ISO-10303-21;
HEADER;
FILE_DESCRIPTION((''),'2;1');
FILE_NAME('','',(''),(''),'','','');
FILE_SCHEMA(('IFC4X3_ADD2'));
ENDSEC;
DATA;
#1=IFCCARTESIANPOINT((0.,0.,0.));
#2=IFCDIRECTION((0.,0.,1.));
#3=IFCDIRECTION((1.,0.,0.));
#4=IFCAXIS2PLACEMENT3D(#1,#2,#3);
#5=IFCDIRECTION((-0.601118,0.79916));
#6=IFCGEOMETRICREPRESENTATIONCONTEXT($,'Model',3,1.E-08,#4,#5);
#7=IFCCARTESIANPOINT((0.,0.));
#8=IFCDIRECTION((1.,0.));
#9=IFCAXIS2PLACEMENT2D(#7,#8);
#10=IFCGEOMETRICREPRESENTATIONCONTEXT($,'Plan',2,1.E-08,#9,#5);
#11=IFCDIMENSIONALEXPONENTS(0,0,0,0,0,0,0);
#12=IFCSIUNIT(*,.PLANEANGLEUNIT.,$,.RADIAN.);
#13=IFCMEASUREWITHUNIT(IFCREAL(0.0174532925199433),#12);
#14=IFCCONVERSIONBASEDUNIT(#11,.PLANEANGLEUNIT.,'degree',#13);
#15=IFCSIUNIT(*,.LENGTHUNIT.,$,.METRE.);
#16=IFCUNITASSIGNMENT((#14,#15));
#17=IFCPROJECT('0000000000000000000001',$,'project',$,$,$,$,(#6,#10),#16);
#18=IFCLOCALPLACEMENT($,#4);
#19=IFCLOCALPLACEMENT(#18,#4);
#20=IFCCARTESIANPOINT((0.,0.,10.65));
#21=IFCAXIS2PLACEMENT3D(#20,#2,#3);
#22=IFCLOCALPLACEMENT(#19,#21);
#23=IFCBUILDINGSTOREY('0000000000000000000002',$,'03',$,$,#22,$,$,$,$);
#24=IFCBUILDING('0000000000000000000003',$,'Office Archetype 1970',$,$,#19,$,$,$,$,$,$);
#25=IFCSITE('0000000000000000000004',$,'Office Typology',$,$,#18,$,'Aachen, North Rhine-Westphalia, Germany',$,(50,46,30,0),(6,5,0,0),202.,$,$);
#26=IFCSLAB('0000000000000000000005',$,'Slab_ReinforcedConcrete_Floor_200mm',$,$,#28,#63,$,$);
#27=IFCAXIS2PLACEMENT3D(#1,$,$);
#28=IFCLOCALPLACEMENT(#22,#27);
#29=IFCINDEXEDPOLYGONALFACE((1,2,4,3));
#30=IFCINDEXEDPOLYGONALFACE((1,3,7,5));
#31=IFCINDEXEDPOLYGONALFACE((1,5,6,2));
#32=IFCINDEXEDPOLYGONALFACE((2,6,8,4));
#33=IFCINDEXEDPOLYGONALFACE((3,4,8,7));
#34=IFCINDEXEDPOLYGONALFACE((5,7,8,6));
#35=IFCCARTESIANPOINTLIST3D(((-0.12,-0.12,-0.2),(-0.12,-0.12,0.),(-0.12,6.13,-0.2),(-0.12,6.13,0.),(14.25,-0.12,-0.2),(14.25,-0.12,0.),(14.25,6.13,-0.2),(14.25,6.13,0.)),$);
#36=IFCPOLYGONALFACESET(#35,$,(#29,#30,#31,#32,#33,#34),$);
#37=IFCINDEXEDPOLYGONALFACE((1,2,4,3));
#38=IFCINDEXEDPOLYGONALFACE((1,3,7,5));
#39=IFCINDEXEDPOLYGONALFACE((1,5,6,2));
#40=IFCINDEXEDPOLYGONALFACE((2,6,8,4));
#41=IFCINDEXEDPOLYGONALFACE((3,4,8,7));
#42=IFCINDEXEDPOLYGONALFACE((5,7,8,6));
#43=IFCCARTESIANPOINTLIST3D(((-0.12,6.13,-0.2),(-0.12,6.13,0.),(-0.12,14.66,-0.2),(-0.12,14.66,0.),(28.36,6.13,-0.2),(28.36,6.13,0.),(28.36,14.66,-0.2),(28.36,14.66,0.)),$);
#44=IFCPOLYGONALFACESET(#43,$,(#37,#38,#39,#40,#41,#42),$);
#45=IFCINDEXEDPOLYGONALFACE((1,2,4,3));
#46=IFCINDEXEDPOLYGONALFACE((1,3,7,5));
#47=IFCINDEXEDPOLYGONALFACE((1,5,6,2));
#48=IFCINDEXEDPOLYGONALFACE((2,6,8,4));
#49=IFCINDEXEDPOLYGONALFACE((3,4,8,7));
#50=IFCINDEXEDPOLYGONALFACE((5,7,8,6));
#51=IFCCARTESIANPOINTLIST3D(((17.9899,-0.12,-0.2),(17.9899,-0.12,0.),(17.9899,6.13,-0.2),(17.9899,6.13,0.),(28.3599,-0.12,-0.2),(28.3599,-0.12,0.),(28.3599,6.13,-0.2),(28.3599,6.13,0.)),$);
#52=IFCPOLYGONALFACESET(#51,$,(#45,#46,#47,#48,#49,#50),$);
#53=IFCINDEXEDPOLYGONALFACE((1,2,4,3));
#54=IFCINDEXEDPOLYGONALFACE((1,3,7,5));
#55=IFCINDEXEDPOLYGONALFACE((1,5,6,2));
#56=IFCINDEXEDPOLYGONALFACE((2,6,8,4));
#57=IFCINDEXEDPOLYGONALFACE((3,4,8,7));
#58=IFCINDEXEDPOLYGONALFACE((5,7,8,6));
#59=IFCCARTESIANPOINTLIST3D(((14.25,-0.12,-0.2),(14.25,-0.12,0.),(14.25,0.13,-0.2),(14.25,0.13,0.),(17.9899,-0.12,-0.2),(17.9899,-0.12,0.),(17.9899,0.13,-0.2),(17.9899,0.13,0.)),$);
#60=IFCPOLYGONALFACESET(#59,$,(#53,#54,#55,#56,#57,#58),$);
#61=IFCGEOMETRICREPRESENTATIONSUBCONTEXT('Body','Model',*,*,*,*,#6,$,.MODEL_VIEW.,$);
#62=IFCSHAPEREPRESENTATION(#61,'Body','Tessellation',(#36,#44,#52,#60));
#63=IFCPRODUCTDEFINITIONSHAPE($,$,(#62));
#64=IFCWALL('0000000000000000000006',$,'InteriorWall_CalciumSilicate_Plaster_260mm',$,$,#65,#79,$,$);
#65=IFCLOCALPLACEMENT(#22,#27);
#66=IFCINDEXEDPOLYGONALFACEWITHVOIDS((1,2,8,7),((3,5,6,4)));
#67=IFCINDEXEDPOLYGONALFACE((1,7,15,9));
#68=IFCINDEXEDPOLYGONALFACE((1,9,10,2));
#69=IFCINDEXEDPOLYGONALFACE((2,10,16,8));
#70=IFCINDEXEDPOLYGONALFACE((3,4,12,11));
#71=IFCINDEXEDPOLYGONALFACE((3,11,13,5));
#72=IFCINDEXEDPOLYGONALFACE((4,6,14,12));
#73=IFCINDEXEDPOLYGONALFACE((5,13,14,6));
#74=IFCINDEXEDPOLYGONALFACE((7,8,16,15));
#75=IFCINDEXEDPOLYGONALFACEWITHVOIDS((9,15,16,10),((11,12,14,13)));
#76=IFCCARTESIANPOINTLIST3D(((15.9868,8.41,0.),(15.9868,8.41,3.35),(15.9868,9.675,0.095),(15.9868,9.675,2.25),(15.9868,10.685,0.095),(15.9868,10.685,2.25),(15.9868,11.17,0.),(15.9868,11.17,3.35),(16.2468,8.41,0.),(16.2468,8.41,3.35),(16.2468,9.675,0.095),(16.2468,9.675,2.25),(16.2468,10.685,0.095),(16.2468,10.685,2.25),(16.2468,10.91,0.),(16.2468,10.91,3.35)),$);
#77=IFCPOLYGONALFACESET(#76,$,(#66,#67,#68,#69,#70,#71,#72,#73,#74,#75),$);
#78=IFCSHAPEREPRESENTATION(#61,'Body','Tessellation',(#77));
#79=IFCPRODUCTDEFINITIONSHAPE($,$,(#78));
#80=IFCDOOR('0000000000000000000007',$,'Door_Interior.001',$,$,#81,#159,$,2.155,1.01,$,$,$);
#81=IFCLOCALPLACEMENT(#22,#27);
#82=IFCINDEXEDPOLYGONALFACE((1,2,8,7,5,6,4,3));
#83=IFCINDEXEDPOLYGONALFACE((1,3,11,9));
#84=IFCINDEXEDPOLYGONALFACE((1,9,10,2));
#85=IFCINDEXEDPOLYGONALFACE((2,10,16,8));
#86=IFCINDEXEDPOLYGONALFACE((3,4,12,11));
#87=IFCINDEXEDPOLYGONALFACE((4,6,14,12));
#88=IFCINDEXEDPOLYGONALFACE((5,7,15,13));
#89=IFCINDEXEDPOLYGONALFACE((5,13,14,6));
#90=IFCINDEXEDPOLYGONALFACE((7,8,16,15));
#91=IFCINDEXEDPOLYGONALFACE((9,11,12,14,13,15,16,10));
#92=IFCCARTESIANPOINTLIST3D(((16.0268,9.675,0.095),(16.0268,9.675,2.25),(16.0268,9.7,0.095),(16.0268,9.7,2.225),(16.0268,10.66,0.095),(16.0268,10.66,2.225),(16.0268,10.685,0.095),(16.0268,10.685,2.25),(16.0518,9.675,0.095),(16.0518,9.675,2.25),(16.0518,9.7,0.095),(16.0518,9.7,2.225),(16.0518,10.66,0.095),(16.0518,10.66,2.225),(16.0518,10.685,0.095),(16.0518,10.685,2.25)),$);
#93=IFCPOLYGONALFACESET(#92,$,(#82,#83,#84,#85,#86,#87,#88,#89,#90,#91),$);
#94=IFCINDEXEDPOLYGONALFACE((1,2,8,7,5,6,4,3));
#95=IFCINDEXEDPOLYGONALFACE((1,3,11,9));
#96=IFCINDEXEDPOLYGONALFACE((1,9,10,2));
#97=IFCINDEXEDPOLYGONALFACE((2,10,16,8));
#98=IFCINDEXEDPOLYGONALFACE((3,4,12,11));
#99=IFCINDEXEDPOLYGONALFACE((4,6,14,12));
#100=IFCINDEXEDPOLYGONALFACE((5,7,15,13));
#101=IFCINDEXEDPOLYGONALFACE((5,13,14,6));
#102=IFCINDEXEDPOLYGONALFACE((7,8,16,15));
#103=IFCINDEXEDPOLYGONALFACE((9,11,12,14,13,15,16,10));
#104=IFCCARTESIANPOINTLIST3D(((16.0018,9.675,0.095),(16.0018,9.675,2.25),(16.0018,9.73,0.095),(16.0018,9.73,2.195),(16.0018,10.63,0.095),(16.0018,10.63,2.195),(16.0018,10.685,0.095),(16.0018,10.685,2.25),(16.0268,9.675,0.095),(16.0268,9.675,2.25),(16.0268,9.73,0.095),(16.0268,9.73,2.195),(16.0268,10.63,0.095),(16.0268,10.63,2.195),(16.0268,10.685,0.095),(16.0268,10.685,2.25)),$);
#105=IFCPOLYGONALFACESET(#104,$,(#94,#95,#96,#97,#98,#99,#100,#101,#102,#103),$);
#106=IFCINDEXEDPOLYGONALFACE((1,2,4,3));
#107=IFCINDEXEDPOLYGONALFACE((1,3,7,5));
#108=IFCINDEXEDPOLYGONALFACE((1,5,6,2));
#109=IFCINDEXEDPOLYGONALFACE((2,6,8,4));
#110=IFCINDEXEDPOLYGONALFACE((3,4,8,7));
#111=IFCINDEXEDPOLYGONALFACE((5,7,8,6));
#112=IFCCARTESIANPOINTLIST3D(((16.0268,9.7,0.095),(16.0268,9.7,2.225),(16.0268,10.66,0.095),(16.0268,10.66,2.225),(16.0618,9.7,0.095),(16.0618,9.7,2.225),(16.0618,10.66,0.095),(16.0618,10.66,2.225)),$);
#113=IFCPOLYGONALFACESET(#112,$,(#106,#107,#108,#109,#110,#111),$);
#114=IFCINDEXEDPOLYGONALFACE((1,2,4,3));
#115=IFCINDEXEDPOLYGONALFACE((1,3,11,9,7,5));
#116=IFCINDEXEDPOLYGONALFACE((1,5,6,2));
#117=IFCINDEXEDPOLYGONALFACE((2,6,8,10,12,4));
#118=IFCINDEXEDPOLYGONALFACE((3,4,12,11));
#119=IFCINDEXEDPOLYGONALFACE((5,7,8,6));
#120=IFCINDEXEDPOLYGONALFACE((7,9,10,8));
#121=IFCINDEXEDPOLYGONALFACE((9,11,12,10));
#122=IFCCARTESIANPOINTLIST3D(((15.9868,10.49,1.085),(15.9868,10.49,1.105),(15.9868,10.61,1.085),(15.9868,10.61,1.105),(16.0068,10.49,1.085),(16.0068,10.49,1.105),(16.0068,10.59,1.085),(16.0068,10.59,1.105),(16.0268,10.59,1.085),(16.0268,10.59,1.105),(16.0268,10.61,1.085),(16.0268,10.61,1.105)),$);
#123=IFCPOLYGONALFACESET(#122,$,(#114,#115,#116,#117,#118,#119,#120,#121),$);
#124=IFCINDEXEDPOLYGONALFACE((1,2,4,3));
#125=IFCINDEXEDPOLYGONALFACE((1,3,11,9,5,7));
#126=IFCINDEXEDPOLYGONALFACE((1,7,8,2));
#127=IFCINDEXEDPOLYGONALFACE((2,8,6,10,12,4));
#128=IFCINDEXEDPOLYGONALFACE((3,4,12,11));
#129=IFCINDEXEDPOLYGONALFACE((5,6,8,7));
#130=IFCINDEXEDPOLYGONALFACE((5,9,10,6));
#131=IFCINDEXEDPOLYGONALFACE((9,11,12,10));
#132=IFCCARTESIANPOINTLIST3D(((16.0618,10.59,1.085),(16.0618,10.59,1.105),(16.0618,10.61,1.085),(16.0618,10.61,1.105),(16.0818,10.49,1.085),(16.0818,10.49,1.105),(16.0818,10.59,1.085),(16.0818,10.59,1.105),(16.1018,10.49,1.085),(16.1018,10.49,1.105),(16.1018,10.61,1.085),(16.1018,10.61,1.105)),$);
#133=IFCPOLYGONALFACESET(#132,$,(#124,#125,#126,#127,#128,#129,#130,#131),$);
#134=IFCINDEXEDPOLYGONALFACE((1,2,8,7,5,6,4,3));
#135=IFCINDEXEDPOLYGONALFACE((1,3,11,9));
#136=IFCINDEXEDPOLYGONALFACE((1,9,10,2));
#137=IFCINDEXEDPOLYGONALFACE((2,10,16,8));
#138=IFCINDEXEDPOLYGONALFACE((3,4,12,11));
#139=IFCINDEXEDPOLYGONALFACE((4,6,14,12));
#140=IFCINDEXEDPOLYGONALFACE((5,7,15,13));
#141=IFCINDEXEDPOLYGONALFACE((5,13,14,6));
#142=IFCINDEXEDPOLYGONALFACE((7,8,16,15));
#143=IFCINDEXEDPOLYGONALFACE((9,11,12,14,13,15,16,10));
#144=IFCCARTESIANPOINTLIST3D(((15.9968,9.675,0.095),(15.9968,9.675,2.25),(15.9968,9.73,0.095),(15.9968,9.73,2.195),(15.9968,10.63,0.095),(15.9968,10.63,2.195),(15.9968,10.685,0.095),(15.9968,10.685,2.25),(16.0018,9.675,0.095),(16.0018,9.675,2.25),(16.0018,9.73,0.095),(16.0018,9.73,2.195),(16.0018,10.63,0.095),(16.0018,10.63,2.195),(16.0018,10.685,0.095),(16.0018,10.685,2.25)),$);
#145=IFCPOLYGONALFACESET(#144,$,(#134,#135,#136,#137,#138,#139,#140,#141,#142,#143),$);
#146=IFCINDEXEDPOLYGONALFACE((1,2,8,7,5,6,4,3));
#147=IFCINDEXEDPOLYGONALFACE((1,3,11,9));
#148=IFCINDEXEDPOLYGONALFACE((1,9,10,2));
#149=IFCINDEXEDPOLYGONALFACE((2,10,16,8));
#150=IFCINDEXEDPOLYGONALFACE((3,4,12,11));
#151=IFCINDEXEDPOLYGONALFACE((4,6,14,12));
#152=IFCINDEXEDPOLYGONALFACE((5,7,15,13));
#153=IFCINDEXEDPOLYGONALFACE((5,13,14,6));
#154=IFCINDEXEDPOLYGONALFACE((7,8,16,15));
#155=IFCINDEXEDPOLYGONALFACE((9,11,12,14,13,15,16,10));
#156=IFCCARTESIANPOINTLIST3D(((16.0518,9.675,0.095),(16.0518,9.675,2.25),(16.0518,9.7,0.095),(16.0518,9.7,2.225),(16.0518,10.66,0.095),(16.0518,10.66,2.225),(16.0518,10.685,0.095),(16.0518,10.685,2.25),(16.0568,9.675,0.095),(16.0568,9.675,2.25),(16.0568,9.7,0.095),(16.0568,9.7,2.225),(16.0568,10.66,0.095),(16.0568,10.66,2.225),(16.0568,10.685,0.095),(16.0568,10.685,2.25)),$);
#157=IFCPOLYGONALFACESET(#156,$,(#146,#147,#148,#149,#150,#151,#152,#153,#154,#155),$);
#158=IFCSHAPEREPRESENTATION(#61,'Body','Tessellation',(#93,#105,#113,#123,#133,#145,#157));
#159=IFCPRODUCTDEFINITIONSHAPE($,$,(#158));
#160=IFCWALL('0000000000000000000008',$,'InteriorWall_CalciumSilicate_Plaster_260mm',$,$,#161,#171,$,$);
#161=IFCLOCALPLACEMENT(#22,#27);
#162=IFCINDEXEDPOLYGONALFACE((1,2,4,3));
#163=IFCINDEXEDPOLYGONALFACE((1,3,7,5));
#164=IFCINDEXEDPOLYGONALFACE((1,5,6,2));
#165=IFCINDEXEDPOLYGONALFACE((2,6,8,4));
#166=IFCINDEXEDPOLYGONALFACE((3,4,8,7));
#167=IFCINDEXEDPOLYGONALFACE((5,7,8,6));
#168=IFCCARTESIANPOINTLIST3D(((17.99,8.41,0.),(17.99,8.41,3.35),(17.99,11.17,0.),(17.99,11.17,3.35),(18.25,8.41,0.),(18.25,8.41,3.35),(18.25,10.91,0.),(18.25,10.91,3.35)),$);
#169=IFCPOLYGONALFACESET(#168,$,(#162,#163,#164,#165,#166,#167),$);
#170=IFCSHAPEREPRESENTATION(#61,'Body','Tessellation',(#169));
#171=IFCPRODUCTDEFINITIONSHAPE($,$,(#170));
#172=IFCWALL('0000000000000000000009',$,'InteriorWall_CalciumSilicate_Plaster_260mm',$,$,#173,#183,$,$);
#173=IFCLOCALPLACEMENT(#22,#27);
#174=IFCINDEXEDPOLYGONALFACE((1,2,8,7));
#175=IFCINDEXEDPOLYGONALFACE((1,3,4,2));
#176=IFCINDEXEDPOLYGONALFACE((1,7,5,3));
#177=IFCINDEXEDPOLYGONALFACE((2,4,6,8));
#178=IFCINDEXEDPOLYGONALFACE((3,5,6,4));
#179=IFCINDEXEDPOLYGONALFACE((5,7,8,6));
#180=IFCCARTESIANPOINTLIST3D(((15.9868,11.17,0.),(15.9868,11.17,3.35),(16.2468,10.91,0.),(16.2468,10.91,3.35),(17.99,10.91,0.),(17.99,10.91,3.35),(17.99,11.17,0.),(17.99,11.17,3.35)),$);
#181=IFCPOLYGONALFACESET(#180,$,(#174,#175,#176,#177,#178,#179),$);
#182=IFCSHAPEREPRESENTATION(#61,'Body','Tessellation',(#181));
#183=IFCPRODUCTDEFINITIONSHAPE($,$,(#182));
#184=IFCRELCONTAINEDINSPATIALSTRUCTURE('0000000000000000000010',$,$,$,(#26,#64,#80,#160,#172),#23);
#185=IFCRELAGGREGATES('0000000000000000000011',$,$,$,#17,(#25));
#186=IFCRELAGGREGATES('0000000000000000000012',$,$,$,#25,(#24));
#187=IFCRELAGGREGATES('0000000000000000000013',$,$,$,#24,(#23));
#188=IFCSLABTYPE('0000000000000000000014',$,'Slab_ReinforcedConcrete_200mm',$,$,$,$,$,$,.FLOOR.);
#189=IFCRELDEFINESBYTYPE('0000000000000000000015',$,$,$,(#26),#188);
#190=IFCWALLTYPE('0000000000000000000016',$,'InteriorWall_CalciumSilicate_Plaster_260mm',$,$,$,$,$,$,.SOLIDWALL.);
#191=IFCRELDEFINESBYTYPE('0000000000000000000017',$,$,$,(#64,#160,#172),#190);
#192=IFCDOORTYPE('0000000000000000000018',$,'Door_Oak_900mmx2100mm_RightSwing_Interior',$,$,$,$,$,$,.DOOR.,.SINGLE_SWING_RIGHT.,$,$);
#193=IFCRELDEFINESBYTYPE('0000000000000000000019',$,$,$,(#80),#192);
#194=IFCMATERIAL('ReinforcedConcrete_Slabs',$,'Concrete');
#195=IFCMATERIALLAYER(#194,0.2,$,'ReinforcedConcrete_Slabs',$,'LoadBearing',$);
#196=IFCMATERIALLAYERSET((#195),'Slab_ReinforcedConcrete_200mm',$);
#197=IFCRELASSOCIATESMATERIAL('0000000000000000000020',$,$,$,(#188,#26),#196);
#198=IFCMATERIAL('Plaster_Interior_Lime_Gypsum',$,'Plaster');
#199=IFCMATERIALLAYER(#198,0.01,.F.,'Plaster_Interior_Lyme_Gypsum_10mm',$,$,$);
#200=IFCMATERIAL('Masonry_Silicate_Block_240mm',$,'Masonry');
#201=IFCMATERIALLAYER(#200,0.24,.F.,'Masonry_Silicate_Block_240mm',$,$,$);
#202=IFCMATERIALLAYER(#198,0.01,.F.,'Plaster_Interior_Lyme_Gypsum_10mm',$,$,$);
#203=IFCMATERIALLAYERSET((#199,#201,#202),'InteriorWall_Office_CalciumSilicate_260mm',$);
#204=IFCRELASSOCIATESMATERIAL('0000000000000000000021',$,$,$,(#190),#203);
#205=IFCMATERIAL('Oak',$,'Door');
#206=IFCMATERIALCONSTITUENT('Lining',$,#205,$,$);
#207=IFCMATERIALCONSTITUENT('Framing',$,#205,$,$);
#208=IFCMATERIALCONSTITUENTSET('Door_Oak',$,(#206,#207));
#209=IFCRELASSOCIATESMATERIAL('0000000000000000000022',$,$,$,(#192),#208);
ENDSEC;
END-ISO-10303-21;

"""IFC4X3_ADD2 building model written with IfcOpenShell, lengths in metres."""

from ifc_helpers import new_model, entity, si_unit, converted_unit, direction, frame, origin_with_axes, origin_2d_with_axis, place, context, subcontext, project, spatial, line, indexed_curve, outline, extrude, source, transform, mapped, material, layer, layer_set, layer_usage, constituent, constituent_set, type_object, type_shapes, element, fill, save


model = new_model("IFC4X3_ADD2")

# Units and contexts
model_context = context("Model", 3, precision=1e-08, world=origin_with_axes(), true_north=direction((-0.601118, 0.79916)))
plan_context = context("Plan", 2, precision=1e-08, world=origin_2d_with_axis(), true_north=direction((-0.601118, 0.79916)))
body_context = subcontext(model_context, "Body", "Model", "MODEL_VIEW")
ifc_project = project(units=[converted_unit("PLANEANGLEUNIT", "degree", entity("IfcReal", 0.0174532925199433), si_unit("PLANEANGLEUNIT", "RADIAN"), dimensions=[0, 0, 0, 0, 0, 0, 0]), si_unit("LENGTHUNIT", "METRE")], contexts=[model_context, plan_context])

# Site, building, storey
site_placement = place(None, origin_with_axes())
site = spatial("IfcSite", under=ifc_project, at=site_placement, Name="Office Typology", LongName="Aachen, North Rhine-Westphalia, Germany", RefLatitude=(50, 46, 30, 0), RefLongitude=(6, 5, 0, 0), RefElevation=202.0)
building_placement = place(site_placement, origin_with_axes())
building = spatial("IfcBuilding", under=site, at=building_placement, Name="Office Archetype 1970")
storey_placement = place(building_placement, frame((0.0, 0.0, 10.65), z_axis=(0.0, 0.0, 1.0), x_axis=(1.0, 0.0, 0.0)))
storey = spatial("IfcBuildingStorey", under=building, at=storey_placement, Name="03")

# Slab
ifc_material_1 = material(Name="ReinforcedConcrete_Slabs", Category="Concrete")
ifc_layer_1 = layer(ifc_material_1, 0.2, Name="ReinforcedConcrete_Slabs", Category="LoadBearing")
ifc_layer_set_1 = layer_set([ifc_layer_1], Name="Slab_ReinforcedConcrete_200mm")
slab_type = type_object("IfcSlabType", Name="Slab_ReinforcedConcrete_200mm", PredefinedType="FLOOR", material=ifc_layer_set_1)
ifc_layer_usage_1 = layer_usage(ifc_layer_set_1, "AXIS3", "POSITIVE", 0.0)
slab_1_placement = place(storey_placement, frame((17.9899, 6.13, 0.0), z_axis=(0.0, 0.0, 1.0), x_axis=(1.0, 0.0, 0.0)))
element("IfcSlab", 1, at=slab_1_placement, inside=storey, type_object=slab_type, material=ifc_layer_usage_1, Name="Slab_ReinforcedConcrete_Floor_200mm", context=body_context, shape_type="SweptSolid", body=[
    extrude(outline(indexed_curve([(0.0, -6.25), (14.37, -6.25), (14.37, 0.0), (0.0, 0.0), (0.0, -6.25)])), frame((-18.1099, 0.0, -0.2), z_axis=(0.0, 0.0, 1.0), x_axis=(1.0, 0.0, 0.0)), (0.0, 0.0, 1.0), 0.2),
    extrude(outline(indexed_curve([(0.0, 0.0), (28.48, 0.0), (28.48, -8.53), (0.0, -8.53), (0.0, 0.0)])), frame((-18.1099, 8.53, -0.2), z_axis=(0.0, 0.0, 1.0), x_axis=(1.0, 0.0, 0.0)), (0.0, 0.0, 1.0), 0.2),
    extrude(outline(indexed_curve([(0.0, 0.0), (0.0, -6.25), (10.37, -6.25), (10.37, 0.0), (0.0, 0.0)])), frame((0.0, 0.0, -0.2), z_axis=(0.0, 0.0, 1.0), x_axis=(1.0, 0.0, 0.0)), (0.0, 0.0, 1.0), 0.2),
    extrude(outline(indexed_curve([(0.0, 0.0), (3.7399, 0.0), (3.7399, 0.25), (0.0, 0.25), (0.0, 0.0)])), frame((-3.7399, -6.25, -0.2), z_axis=(0.0, 0.0, 1.0), x_axis=(1.0, 0.0, 0.0)), (0.0, 0.0, 1.0), 0.2),
])

# Wall, opening, door
ifc_material_2 = material(Name="Plaster_Interior_Lime_Gypsum", Category="Plaster")
ifc_layer_2 = layer(ifc_material_2, 0.01, ventilated=False, Name="Plaster_Interior_Lyme_Gypsum_10mm")
ifc_material_3 = material(Name="Masonry_Silicate_Block_240mm", Category="Masonry")
ifc_layer_3 = layer(ifc_material_3, 0.24, ventilated=False, Name="Masonry_Silicate_Block_240mm")
ifc_layer_4 = layer(ifc_material_2, 0.01, ventilated=False, Name="Plaster_Interior_Lyme_Gypsum_10mm")
ifc_layer_set_2 = layer_set([ifc_layer_2, ifc_layer_3, ifc_layer_4], Name="InteriorWall_Office_CalciumSilicate_260mm")
wall_type_1 = type_object("IfcWallType", Name="InteriorWall_CalciumSilicate_Plaster_260mm", PredefinedType="SOLIDWALL", material=ifc_layer_set_2)
wall_1_placement = place(storey_placement, frame((15.9868, 11.17, 0.0), z_axis=(0.0, 0.0, 1.0), x_axis=(0.0, -1.0, 0.0)))
wall_1 = element("IfcWall", 2, at=wall_1_placement, inside=storey, type_object=wall_type_1, Name="InteriorWall_CalciumSilicate_Plaster_260mm", context=body_context, shape_type="SweptSolid", body=[
    extrude(outline(indexed_curve([(2.76, 0.0), (2.76, 0.26), (0.26, 0.26), (0.0, 0.0), (2.76, 0.0)])), origin_with_axes(), (0.0, 0.0, 1.0), 3.35),
])
shared_shape_1 = source(origin_with_axes(), body_context, "Body", "SweptSolid", [
    extrude(outline(indexed_curve([(0.0, 0.0), (1.01, 0.0), (1.01, 2.155), (0.0, 2.155), (0.0, 0.0)])), frame((0.0, -0.015, 0.0), z_axis=(0.0, -1.0, 0.0), x_axis=(1.0, 0.0, 0.0)), (0.0, 0.0, -1.0), 0.26),
])
opening_1_placement = place(wall_1_placement, frame((0.485, 0.015, 0.095), z_axis=(0.0, 0.0, 1.0), x_axis=(1.0, 0.0, 0.0)))
opening_1 = element("IfcOpeningElement", 3, at=opening_1_placement, cuts=wall_1, PredefinedType="OPENING", context=body_context, shape_type="MappedRepresentation", body=[
    mapped(shared_shape_1, transform((0.0, 0.0, 0.0), x_axis=(1.0, 0.0, 0.0), y_axis=(0.0, 1.0, 0.0), z_axis=(0.0, 0.0, 1.0), scale=1.0)),
])
ifc_material_4 = material(Name="Oak", Category="Door")
ifc_constituent_1 = constituent(ifc_material_4, Name="Lining")
ifc_constituent_2 = constituent(ifc_material_4, Name="Framing")
ifc_constituent_set_1 = constituent_set(constituents=[ifc_constituent_1, ifc_constituent_2], Name="Door_Oak")
door_type_1 = type_object("IfcDoorType", Name="Door_Oak_900mmx2100mm_RightSwing_Interior", OperationType="SINGLE_SWING_RIGHT", PredefinedType="DOOR", material=ifc_constituent_set_1)
shared_shape_2 = source(origin_with_axes(), body_context, "Body", "SweptSolid", [
    extrude(outline(indexed_curve([(0.0, 0.0), (0.0, 2.155), (1.01, 2.155), (1.01, 0.0), (0.985, 0.0), (0.985, 2.13), (0.025, 2.13), (0.025, 0.0)], segments=[line(1, 2, 3, 4, 5, 6, 7, 8, 1)])), frame((0.0, 0.025, 0.0), z_axis=(0.0, -1.0, 0.0), x_axis=(1.0, 0.0, 0.0)), (0.0, 0.0, -1.0), 0.025),
    extrude(outline(indexed_curve([(0.0, 0.0), (0.0, 2.155), (1.01, 2.155), (1.01, 0.0), (0.955, 0.0), (0.955, 2.1), (0.055, 2.1), (0.055, 0.0)], segments=[line(1, 2, 3, 4, 5, 6, 7, 8, 1)])), frame((0.0, 0.0, 0.0), z_axis=(0.0, -1.0, 0.0), x_axis=(1.0, 0.0, 0.0)), (0.0, 0.0, -1.0), 0.025),
    extrude(outline(indexed_curve([(0.0, 0.0), (0.96, 0.0), (0.96, 0.035), (0.0, 0.035)], segments=[line(1, 2, 3, 4, 1)])), frame((0.025, 0.025, 0.0), z_axis=(0.0, 0.0, 1.0), x_axis=(1.0, 0.0, 0.0)), (0.0, 0.0, 1.0), 2.13),
    extrude(outline(indexed_curve([(0.0, 0.0), (0.0, -0.04), (0.12, -0.04), (0.12, -0.02), (0.02, -0.02), (0.02, 0.0)], segments=[line(1, 2, 3, 4, 5, 6, 1)])), frame((0.075, 0.025, 0.99), z_axis=(0.0, 0.0, 1.0), x_axis=(1.0, 0.0, 0.0)), (0.0, 0.0, 1.0), 0.02),
    extrude(outline(indexed_curve([(0.0, 0.0), (0.0, 0.04), (0.12, 0.04), (0.12, 0.02), (0.02, 0.02), (0.02, 0.0)], segments=[line(1, 2, 3, 4, 5, 6, 1)])), frame((0.075, 0.06, 0.99), z_axis=(0.0, 0.0, 1.0), x_axis=(1.0, 0.0, 0.0)), (0.0, 0.0, 1.0), 0.02),
    extrude(outline(indexed_curve([(0.0, 0.0), (0.0, 2.155), (1.01, 2.155), (1.01, 0.0), (0.955, 0.0), (0.955, 2.1), (0.055, 2.1), (0.055, 0.0)], segments=[line(1, 2, 3, 4, 5, 6, 7, 8, 1)])), frame((0.0, -0.005, 0.0), z_axis=(0.0, -1.0, 0.0), x_axis=(1.0, 0.0, 0.0)), (0.0, 0.0, -1.0), 0.005),
    extrude(outline(indexed_curve([(0.0, 0.0), (0.0, 2.155), (1.01, 2.155), (1.01, 0.0), (0.985, 0.0), (0.985, 2.13), (0.025, 2.13), (0.025, 0.0)], segments=[line(1, 2, 3, 4, 5, 6, 7, 8, 1)])), frame((0.0, 0.05, 0.0), z_axis=(0.0, -1.0, 0.0), x_axis=(1.0, 0.0, 0.0)), (0.0, 0.0, -1.0), 0.005),
])
type_shapes(door_type_1, [shared_shape_2])
door_1_placement = place(opening_1_placement, origin_with_axes())
door_1 = element("IfcDoor", 4, at=door_1_placement, inside=storey, type_object=door_type_1, Name="Door_Interior.001", OverallHeight=2.155, OverallWidth=1.01, context=body_context, shape_type="MappedRepresentation", body=[
    mapped(shared_shape_2, transform((0.0, 0.0, 0.0), x_axis=(1.0, 0.0, 0.0), y_axis=(0.0, 1.0, 0.0), z_axis=(0.0, 0.0, 1.0), scale=1.0)),
])
fill(opening_1, door_1)

# Walls
wall_2_placement = place(storey_placement, frame((17.99, 11.17, 0.0), z_axis=(0.0, 0.0, 1.0), x_axis=(0.0, -1.0, 0.0)))
element("IfcWall", 5, at=wall_2_placement, inside=storey, type_object=wall_type_1, Name="InteriorWall_CalciumSilicate_Plaster_260mm", context=body_context, shape_type="SweptSolid", body=[
    extrude(outline(indexed_curve([(0.0, 0.0), (0.26, 0.26), (2.76, 0.26), (2.76, 0.0)], segments=[line(1, 2, 3, 4, 1)])), origin_with_axes(), (0.0, 0.0, 1.0), 3.35),
])
wall_3_placement = place(storey_placement, frame((17.99, 11.17, 0.0), z_axis=(0.0, 0.0, 1.0), x_axis=(-1.0, 0.0, 0.0)))
element("IfcWall", 6, at=wall_3_placement, inside=storey, type_object=wall_type_1, Name="InteriorWall_CalciumSilicate_Plaster_260mm", context=body_context, shape_type="SweptSolid", body=[
    extrude(outline(indexed_curve([(0.0, 0.0), (0.0, 0.26), (1.7432, 0.26), (2.0032, 0.0)], segments=[line(1, 2, 3, 4, 1)])), origin_with_axes(), (0.0, 0.0, 1.0), 3.35),
])

save(model, "model.ifc")
